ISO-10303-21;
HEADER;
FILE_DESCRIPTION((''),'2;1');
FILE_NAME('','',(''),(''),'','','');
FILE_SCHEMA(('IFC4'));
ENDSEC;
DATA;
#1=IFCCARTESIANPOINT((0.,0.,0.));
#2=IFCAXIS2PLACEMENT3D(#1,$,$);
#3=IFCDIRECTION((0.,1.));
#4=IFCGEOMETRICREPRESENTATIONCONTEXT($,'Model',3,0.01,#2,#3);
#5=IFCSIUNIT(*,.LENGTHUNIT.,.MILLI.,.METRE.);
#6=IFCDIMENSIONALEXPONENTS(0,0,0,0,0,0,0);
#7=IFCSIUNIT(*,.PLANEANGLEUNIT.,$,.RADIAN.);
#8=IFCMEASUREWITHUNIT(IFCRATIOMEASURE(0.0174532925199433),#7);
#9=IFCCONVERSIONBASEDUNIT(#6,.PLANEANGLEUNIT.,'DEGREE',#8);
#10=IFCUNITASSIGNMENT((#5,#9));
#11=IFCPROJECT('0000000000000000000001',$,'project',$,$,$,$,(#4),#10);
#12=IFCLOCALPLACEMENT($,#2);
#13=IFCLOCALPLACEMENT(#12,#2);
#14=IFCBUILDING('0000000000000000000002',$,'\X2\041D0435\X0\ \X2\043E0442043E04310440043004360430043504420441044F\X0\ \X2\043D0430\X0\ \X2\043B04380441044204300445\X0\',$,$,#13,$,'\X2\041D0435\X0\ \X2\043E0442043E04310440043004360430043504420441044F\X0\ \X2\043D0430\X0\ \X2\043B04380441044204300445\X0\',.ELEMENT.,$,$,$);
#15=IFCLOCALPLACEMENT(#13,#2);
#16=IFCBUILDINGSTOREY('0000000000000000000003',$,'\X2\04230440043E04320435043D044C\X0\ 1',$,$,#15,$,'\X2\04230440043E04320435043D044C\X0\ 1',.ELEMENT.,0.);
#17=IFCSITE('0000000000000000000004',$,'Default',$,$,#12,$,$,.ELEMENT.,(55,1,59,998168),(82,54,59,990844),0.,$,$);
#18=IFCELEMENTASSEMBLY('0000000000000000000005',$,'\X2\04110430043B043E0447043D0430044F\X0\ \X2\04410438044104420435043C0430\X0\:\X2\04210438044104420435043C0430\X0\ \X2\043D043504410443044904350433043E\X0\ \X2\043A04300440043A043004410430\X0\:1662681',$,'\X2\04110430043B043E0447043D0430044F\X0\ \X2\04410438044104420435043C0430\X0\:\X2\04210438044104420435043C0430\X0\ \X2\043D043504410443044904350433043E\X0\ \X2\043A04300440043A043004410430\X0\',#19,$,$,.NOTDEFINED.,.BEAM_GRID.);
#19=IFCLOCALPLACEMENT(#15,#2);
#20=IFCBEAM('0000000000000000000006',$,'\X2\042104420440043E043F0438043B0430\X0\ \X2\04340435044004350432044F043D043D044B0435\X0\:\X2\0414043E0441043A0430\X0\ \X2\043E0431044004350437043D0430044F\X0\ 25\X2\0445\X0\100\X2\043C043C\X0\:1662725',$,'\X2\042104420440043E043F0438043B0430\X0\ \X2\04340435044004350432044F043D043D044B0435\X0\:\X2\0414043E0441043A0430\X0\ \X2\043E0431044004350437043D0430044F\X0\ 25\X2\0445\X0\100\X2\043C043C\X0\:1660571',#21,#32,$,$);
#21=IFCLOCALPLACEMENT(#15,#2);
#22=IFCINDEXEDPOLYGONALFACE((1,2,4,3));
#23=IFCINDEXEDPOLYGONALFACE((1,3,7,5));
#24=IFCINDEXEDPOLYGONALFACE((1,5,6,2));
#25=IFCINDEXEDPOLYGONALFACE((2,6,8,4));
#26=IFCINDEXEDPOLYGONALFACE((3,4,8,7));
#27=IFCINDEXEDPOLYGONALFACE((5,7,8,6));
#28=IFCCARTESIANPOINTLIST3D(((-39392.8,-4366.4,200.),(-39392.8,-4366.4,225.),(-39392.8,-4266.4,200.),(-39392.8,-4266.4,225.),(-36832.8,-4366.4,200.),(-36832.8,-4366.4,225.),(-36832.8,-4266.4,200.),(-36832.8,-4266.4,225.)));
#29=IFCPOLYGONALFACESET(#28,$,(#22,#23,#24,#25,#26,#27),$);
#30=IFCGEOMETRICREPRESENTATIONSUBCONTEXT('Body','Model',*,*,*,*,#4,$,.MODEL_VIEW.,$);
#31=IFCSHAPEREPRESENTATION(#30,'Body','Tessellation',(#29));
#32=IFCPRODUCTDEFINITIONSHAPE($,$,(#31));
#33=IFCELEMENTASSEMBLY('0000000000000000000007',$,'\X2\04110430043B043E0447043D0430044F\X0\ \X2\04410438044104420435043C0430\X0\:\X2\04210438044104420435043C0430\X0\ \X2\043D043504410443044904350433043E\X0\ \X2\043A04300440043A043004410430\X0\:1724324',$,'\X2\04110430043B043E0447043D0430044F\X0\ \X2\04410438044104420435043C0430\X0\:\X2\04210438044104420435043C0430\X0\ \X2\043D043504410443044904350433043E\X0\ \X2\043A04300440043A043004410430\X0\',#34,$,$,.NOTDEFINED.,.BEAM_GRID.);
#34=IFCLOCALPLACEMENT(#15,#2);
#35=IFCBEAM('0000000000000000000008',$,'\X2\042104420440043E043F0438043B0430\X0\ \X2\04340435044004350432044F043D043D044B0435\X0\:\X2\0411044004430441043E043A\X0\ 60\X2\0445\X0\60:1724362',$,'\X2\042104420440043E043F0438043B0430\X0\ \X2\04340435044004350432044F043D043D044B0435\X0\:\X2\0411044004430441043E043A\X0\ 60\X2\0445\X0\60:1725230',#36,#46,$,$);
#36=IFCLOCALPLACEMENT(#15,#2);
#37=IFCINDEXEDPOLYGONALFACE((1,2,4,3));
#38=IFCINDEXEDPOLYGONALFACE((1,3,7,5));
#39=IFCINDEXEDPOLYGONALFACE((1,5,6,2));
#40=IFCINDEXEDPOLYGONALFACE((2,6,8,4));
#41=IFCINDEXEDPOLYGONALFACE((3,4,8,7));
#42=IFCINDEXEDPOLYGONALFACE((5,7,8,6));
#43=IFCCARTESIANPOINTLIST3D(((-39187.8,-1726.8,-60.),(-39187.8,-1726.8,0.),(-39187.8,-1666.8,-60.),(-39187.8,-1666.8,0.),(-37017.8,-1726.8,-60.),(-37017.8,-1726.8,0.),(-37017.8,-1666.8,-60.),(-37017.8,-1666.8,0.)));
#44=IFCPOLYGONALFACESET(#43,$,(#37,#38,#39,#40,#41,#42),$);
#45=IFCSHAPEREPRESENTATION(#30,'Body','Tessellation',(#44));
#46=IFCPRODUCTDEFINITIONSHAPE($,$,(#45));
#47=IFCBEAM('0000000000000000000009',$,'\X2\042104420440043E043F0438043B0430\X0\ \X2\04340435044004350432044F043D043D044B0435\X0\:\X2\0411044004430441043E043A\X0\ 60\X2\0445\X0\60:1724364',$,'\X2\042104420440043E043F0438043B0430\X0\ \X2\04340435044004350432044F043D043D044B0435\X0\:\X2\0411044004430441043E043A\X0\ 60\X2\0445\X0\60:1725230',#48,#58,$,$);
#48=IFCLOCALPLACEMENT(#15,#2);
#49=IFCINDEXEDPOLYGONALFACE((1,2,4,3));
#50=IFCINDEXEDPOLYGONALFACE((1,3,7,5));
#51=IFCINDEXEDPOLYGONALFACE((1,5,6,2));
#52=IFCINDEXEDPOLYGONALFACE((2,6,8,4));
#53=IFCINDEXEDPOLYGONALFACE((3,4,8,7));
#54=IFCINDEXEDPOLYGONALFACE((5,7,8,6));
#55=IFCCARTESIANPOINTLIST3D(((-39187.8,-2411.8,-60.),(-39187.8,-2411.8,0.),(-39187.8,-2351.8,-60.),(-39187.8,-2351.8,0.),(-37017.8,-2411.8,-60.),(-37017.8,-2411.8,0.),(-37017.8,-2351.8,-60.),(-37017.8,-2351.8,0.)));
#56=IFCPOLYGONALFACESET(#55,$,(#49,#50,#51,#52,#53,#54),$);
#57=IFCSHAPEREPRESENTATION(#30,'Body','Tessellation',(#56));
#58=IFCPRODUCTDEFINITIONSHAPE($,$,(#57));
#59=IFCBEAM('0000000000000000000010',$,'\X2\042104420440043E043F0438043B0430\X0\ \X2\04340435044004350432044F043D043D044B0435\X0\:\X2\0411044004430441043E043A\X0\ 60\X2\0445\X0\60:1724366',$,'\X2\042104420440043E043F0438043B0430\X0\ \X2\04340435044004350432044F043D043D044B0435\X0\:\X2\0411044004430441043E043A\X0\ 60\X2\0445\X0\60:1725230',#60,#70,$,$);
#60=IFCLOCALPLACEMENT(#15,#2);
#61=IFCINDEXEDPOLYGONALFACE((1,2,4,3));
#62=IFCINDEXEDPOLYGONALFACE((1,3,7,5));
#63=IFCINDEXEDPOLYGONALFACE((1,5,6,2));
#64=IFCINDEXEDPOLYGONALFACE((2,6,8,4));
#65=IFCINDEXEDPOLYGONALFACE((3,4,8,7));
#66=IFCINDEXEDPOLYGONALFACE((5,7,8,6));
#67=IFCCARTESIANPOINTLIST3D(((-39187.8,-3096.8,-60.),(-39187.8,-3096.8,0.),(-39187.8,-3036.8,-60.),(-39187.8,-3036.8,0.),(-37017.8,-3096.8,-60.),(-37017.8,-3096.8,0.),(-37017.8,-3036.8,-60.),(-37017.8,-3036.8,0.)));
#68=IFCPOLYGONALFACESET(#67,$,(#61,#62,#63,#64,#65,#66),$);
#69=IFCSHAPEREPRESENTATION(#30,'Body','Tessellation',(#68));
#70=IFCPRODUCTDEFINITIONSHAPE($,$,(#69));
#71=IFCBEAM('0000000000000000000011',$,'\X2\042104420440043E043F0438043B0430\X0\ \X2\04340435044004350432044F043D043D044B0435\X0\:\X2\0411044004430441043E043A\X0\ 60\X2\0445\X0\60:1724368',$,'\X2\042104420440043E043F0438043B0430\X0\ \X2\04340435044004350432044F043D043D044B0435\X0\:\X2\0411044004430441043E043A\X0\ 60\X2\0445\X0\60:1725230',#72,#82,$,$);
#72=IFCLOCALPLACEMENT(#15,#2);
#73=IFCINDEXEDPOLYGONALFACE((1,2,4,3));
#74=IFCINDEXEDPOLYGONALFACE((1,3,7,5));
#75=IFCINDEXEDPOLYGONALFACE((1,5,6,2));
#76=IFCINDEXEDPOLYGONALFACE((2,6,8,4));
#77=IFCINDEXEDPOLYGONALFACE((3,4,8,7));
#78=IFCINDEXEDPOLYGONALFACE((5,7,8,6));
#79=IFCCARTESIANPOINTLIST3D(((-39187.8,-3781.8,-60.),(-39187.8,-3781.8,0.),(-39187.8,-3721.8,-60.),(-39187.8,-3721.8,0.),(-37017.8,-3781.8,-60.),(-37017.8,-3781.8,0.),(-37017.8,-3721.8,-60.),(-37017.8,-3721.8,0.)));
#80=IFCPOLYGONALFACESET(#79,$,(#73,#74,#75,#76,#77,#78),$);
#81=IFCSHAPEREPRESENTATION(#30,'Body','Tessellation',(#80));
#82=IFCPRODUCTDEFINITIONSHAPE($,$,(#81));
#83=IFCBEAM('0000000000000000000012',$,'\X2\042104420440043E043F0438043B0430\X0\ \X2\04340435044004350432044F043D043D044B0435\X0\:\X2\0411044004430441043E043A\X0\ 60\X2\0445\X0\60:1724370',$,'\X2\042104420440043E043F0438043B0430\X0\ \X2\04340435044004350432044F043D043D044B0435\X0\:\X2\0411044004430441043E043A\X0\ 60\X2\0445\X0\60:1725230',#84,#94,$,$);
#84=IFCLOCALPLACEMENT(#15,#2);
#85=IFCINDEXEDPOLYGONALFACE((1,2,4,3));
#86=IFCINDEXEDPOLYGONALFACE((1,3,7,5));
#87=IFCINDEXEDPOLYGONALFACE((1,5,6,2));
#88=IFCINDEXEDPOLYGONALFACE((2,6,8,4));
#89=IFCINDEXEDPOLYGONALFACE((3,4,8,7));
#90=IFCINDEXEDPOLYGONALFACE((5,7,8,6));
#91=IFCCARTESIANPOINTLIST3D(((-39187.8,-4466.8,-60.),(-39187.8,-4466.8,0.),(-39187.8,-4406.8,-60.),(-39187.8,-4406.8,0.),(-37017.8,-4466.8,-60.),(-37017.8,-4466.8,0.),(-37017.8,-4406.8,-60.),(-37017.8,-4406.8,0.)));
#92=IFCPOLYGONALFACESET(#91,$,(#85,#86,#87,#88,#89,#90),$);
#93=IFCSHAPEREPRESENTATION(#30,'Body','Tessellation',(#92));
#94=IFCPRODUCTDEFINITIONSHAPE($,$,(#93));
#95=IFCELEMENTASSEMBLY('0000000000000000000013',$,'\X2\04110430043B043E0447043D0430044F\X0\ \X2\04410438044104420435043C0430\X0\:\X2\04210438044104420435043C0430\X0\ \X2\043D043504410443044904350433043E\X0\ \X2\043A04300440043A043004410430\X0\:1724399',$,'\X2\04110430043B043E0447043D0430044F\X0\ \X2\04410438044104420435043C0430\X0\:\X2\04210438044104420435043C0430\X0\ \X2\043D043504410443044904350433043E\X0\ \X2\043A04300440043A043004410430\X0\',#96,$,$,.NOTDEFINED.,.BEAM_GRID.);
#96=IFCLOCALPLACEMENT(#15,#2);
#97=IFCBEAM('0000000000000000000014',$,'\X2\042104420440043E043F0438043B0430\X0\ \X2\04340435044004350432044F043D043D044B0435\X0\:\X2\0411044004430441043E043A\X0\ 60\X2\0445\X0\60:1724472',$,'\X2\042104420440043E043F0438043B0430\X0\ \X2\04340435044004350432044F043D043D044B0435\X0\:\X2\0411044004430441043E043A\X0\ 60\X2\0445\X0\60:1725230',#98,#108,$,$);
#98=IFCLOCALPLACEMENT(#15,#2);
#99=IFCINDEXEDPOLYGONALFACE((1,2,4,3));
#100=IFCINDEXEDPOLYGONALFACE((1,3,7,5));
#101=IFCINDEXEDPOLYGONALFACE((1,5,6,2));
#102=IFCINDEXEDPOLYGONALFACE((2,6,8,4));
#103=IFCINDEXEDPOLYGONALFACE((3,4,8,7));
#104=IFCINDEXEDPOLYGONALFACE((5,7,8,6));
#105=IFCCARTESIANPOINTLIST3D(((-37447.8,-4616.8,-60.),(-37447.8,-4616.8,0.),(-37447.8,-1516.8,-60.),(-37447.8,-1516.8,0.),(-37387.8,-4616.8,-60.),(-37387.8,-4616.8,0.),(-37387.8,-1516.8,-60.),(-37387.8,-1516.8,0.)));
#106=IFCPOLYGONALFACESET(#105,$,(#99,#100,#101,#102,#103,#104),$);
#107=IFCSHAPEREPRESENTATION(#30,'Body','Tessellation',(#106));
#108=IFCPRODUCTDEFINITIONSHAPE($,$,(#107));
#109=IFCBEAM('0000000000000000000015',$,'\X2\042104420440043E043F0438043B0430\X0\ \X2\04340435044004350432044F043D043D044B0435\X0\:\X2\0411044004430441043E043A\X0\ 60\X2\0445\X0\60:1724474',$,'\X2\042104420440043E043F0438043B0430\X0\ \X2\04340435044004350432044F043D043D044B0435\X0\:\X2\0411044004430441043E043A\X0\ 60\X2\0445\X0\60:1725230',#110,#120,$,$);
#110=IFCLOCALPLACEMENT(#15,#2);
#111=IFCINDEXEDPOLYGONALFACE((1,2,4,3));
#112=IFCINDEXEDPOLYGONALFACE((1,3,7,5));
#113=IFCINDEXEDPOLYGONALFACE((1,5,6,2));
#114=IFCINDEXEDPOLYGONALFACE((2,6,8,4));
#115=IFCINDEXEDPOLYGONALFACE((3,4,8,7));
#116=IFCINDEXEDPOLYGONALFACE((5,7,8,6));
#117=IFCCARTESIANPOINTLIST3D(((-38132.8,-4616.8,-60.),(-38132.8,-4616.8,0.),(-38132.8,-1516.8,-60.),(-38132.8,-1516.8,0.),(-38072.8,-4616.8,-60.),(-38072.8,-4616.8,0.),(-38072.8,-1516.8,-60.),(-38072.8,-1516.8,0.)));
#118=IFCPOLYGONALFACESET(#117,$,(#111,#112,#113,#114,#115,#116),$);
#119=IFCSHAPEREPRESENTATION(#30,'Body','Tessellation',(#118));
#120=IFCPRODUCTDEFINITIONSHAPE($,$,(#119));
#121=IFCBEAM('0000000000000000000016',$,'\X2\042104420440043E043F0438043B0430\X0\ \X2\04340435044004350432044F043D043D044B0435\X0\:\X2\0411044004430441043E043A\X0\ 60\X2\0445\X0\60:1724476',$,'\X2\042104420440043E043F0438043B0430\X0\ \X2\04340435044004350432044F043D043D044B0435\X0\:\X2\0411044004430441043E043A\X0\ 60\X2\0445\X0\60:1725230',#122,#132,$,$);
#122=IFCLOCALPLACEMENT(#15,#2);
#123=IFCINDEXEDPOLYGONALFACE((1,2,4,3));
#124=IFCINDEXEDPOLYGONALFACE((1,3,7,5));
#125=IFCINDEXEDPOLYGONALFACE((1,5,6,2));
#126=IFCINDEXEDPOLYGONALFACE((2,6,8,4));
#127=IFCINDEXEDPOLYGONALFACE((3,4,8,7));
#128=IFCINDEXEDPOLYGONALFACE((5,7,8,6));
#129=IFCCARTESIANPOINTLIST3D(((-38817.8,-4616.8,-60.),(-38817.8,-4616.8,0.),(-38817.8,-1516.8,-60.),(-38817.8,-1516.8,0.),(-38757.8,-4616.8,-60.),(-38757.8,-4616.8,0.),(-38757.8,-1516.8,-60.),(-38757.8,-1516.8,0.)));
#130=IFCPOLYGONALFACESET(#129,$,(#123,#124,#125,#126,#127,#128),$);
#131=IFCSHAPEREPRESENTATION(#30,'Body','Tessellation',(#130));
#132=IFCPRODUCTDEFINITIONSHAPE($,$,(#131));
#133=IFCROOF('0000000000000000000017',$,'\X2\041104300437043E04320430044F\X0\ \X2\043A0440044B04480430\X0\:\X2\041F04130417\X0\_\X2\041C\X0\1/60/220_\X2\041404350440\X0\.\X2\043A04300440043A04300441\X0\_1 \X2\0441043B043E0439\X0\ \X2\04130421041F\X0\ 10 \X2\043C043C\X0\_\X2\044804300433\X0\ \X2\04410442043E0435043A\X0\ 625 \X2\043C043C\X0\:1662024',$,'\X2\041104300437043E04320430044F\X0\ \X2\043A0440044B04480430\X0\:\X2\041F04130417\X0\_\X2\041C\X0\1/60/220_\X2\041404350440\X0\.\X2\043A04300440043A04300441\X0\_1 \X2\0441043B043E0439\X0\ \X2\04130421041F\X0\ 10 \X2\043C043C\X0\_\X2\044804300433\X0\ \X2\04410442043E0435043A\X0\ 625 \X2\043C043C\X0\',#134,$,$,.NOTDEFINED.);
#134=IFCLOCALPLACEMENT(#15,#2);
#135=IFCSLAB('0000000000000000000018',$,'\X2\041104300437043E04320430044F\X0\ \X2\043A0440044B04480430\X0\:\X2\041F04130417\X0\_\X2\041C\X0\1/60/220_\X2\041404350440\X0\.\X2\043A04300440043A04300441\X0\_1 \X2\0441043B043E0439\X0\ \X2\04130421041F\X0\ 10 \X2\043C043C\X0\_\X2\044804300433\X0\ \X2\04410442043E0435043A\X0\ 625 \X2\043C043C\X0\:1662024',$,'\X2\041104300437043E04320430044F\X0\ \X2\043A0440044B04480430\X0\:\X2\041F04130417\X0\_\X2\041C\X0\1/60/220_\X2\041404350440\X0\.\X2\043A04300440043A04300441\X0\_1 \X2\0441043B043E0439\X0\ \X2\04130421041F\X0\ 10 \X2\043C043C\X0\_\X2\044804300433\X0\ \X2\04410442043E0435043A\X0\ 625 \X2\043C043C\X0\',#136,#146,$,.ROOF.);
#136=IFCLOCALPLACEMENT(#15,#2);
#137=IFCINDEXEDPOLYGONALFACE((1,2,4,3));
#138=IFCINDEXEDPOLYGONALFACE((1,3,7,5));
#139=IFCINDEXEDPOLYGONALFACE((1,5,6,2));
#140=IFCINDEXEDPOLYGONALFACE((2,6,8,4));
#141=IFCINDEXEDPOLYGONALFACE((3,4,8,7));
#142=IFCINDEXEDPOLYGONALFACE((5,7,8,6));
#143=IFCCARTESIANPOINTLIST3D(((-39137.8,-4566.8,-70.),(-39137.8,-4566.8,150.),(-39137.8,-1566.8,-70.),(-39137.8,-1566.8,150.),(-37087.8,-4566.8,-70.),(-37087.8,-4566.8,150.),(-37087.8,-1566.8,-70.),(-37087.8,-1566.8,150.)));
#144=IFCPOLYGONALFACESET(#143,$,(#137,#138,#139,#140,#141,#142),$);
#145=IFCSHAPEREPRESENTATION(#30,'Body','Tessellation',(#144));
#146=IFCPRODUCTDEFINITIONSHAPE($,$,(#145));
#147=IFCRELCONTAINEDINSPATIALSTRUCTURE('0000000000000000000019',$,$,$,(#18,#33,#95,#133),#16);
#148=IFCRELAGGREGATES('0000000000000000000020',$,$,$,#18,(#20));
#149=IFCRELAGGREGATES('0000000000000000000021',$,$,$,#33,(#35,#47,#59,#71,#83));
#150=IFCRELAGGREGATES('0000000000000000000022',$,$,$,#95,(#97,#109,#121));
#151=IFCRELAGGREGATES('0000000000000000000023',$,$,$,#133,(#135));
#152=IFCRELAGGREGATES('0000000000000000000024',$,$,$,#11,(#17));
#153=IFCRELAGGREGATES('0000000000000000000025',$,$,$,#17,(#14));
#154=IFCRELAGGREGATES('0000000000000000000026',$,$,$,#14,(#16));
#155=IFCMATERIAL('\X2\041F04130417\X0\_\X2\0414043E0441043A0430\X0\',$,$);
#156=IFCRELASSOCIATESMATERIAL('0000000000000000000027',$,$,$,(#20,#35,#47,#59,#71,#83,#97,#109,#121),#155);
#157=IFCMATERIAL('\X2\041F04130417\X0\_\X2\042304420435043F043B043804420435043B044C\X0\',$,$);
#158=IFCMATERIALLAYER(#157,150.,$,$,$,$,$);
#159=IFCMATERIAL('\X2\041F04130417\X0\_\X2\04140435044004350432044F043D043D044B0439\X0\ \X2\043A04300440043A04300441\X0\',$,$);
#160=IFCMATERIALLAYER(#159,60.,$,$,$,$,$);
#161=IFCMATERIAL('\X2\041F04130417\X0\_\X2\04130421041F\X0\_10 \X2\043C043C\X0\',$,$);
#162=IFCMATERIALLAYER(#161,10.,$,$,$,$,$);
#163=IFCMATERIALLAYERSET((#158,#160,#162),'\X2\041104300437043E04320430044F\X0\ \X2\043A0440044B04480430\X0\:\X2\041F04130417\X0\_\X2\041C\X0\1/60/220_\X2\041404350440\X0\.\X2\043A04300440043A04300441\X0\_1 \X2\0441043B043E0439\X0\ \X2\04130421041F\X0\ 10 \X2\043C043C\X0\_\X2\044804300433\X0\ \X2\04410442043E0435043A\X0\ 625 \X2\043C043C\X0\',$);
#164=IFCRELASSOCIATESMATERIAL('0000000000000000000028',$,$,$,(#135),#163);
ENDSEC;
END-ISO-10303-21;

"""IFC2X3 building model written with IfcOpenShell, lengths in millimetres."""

from ifc_helpers import new_model, entity, si_unit, converted_unit, direction, frame, frame_2d, origin, origin_2d_with_axis, place, context, subcontext, project, spatial, rectangle, extrude, material, layer, layer_set, element, aggregate, save


model = new_model("IFC2X3")

# Units and contexts
model_context = context("Model", 3, precision=0.01, world=origin(), true_north=direction((0.0, 1.0)))
body_context = subcontext(model_context, "Body", "Model", "MODEL_VIEW")
ifc_project = project(units=[si_unit("LENGTHUNIT", "METRE", prefix="MILLI"), converted_unit("PLANEANGLEUNIT", "DEGREE", entity("IfcRatioMeasure", 0.0174532925199433), si_unit("PLANEANGLEUNIT", "RADIAN"), dimensions=[0, 0, 0, 0, 0, 0, 0])], contexts=[model_context])

# Site, building, storey
site_placement = place(None, origin())
site = spatial("IfcSite", under=ifc_project, at=site_placement, Name="Default", CompositionType="ELEMENT", RefLatitude=(55, 1, 59, 998168), RefLongitude=(82, 54, 59, 990844), RefElevation=0.0)
building_placement = place(site_placement, origin())
building = spatial("IfcBuilding", under=site, at=building_placement, Name="Не отображается на листах", LongName="Не отображается на листах", CompositionType="ELEMENT")
storey_placement = place(building_placement, frame((0.0, 0.0, 0.0)))
storey = spatial("IfcBuildingStorey", under=building, at=storey_placement, Name="Уровень 1", LongName="Уровень 1", CompositionType="ELEMENT", Elevation=0.0)

# Element assemblies, beams
ifc_material_1 = material(Name="ПГЗ_Доска")
assembly_1_placement = place(storey_placement, origin())
assembly_1 = element("IfcElementAssembly", 1, at=assembly_1_placement, inside=storey, Name="Балочная система:Система несущего каркаса:1662681", ObjectType="Балочная система:Система несущего каркаса", AssemblyPlace="NOTDEFINED", PredefinedType="BEAM_GRID")
beam_1_placement = place(assembly_1_placement, frame((-39392.8, -4316.4, 0.0)))
beam_1 = element("IfcBeam", 2, at=beam_1_placement, material=ifc_material_1, Name="Стропила деревянные:Доска обрезная 25х100мм:1662725", ObjectType="Стропила деревянные:Доска обрезная 25х100мм:1660571", context=body_context, shape_type="SweptSolid", body=[
    extrude(rectangle(XDim=25.0, YDim=100.0, at=origin_2d_with_axis()), frame((0.0, 0.0, 212.5), z_axis=(1.0, 0.0, 0.0), x_axis=(0.0, 0.0, -1.0)), (0.0, 0.0, 1.0), 2560.0),
])
aggregate(assembly_1, [beam_1])
assembly_2_placement = place(storey_placement, origin())
assembly_2 = element("IfcElementAssembly", 3, at=assembly_2_placement, inside=storey, Name="Балочная система:Система несущего каркаса:1724324", ObjectType="Балочная система:Система несущего каркаса", AssemblyPlace="NOTDEFINED", PredefinedType="BEAM_GRID")
beam_2_placement = place(assembly_2_placement, frame((-39187.8, -1696.8, 0.0)))
beam_2 = element("IfcBeam", 4, at=beam_2_placement, material=ifc_material_1, Name="Стропила деревянные:Брусок 60х60:1724362", ObjectType="Стропила деревянные:Брусок 60х60:1725230", context=body_context, shape_type="SweptSolid", body=[
    extrude(rectangle(XDim=60.0, YDim=60.0, at=frame_2d((0.0, 0.0), x_axis=(1.0, 0.0))), frame((0.0, 0.0, -30.0), z_axis=(1.0, 0.0, 0.0), x_axis=(0.0, 0.0, -1.0)), (0.0, 0.0, 1.0), 2170.0),
])
beam_3_placement = place(assembly_2_placement, frame((-39187.8, -2381.8, 0.0)))
beam_3 = element("IfcBeam", 5, at=beam_3_placement, material=ifc_material_1, Name="Стропила деревянные:Брусок 60х60:1724364", ObjectType="Стропила деревянные:Брусок 60х60:1725230", context=body_context, shape_type="SweptSolid", body=[
    extrude(rectangle(XDim=60.0, YDim=60.0, at=frame_2d((0.0, 0.0), x_axis=(1.0, 0.0))), frame((0.0, 0.0, -30.0), z_axis=(1.0, 0.0, 0.0), x_axis=(0.0, 0.0, -1.0)), (0.0, 0.0, 1.0), 2170.0),
])
beam_4_placement = place(assembly_2_placement, frame((-39187.8, -3066.8, 0.0)))
beam_4 = element("IfcBeam", 6, at=beam_4_placement, material=ifc_material_1, Name="Стропила деревянные:Брусок 60х60:1724366", ObjectType="Стропила деревянные:Брусок 60х60:1725230", context=body_context, shape_type="SweptSolid", body=[
    extrude(rectangle(XDim=60.0, YDim=60.0, at=frame_2d((0.0, 0.0), x_axis=(1.0, 0.0))), frame((0.0, 0.0, -30.0), z_axis=(1.0, 0.0, 0.0), x_axis=(0.0, 0.0, -1.0)), (0.0, 0.0, 1.0), 2170.0),
])
beam_5_placement = place(assembly_2_placement, frame((-39187.8, -3751.8, 0.0)))
beam_5 = element("IfcBeam", 7, at=beam_5_placement, material=ifc_material_1, Name="Стропила деревянные:Брусок 60х60:1724368", ObjectType="Стропила деревянные:Брусок 60х60:1725230", context=body_context, shape_type="SweptSolid", body=[
    extrude(rectangle(XDim=60.0, YDim=60.0, at=frame_2d((0.0, 0.0), x_axis=(1.0, 0.0))), frame((0.0, 0.0, -30.0), z_axis=(1.0, 0.0, 0.0), x_axis=(0.0, 0.0, -1.0)), (0.0, 0.0, 1.0), 2170.0),
])
beam_6_placement = place(assembly_2_placement, frame((-39187.8, -4436.8, 0.0)))
beam_6 = element("IfcBeam", 8, at=beam_6_placement, material=ifc_material_1, Name="Стропила деревянные:Брусок 60х60:1724370", ObjectType="Стропила деревянные:Брусок 60х60:1725230", context=body_context, shape_type="SweptSolid", body=[
    extrude(rectangle(XDim=60.0, YDim=60.0, at=frame_2d((0.0, 0.0), x_axis=(1.0, 0.0))), frame((0.0, 0.0, -30.0), z_axis=(1.0, 0.0, 0.0), x_axis=(0.0, 0.0, -1.0)), (0.0, 0.0, 1.0), 2170.0),
])
aggregate(assembly_2, [beam_2, beam_3, beam_4, beam_5, beam_6])
assembly_3_placement = place(storey_placement, origin())
assembly_3 = element("IfcElementAssembly", 9, at=assembly_3_placement, inside=storey, Name="Балочная система:Система несущего каркаса:1724399", ObjectType="Балочная система:Система несущего каркаса", AssemblyPlace="NOTDEFINED", PredefinedType="BEAM_GRID")
beam_7_placement = place(assembly_3_placement, frame((-37417.8, -1516.8, 0.0), z_axis=(0.0, 0.0, 1.0), x_axis=(0.0, -1.0, 0.0)))
beam_7 = element("IfcBeam", 10, at=beam_7_placement, material=ifc_material_1, Name="Стропила деревянные:Брусок 60х60:1724472", ObjectType="Стропила деревянные:Брусок 60х60:1725230", context=body_context, shape_type="SweptSolid", body=[
    extrude(rectangle(XDim=60.0, YDim=60.0, at=frame_2d((0.0, 0.0), x_axis=(1.0, 0.0))), frame((0.0, 0.0, -30.0), z_axis=(1.0, 0.0, 0.0), x_axis=(0.0, 0.0, -1.0)), (0.0, 0.0, 1.0), 3100.0),
])
beam_8_placement = place(assembly_3_placement, frame((-38102.8, -1516.8, 0.0), z_axis=(0.0, 0.0, 1.0), x_axis=(0.0, -1.0, 0.0)))
beam_8 = element("IfcBeam", 11, at=beam_8_placement, material=ifc_material_1, Name="Стропила деревянные:Брусок 60х60:1724474", ObjectType="Стропила деревянные:Брусок 60х60:1725230", context=body_context, shape_type="SweptSolid", body=[
    extrude(rectangle(XDim=60.0, YDim=60.0, at=frame_2d((0.0, 0.0), x_axis=(1.0, 0.0))), frame((0.0, 0.0, -30.0), z_axis=(1.0, 0.0, 0.0), x_axis=(0.0, 0.0, -1.0)), (0.0, 0.0, 1.0), 3100.0),
])
beam_9_placement = place(assembly_3_placement, frame((-38787.8, -1516.8, 0.0), z_axis=(0.0, 0.0, 1.0), x_axis=(0.0, -1.0, 0.0)))
beam_9 = element("IfcBeam", 12, at=beam_9_placement, material=ifc_material_1, Name="Стропила деревянные:Брусок 60х60:1724476", ObjectType="Стропила деревянные:Брусок 60х60:1725230", context=body_context, shape_type="SweptSolid", body=[
    extrude(rectangle(XDim=60.0, YDim=60.0, at=frame_2d((0.0, 0.0), x_axis=(1.0, 0.0))), frame((0.0, 0.0, -30.0), z_axis=(1.0, 0.0, 0.0), x_axis=(0.0, 0.0, -1.0)), (0.0, 0.0, 1.0), 3100.0),
])
aggregate(assembly_3, [beam_7, beam_8, beam_9])

# Roof, slab
roof_placement = place(storey_placement, frame((-39137.8, -4566.8, -70.0)))
roof = element("IfcRoof", 13, at=roof_placement, inside=storey, Name="Базовая крыша:ПГЗ_М1/60/220_Дер.каркас_1 слой ГСП 10 мм_шаг стоек 625 мм:1662024", ObjectType="Базовая крыша:ПГЗ_М1/60/220_Дер.каркас_1 слой ГСП 10 мм_шаг стоек 625 мм", ShapeType="NOTDEFINED")
ifc_material_2 = material(Name="ПГЗ_Утеплитель")
ifc_layer_1 = layer(ifc_material_2, 150.0)
ifc_material_3 = material(Name="ПГЗ_Деревянный каркас")
ifc_layer_2 = layer(ifc_material_3, 60.0)
ifc_material_4 = material(Name="ПГЗ_ГСП_10 мм")
ifc_layer_3 = layer(ifc_material_4, 10.0)
ifc_layer_set = layer_set([ifc_layer_1, ifc_layer_2, ifc_layer_3], Name="Базовая крыша:ПГЗ_М1/60/220_Дер.каркас_1 слой ГСП 10 мм_шаг стоек 625 мм")
slab_placement = place(roof_placement, origin())
slab = element("IfcSlab", 14, at=slab_placement, material=ifc_layer_set, Name="Базовая крыша:ПГЗ_М1/60/220_Дер.каркас_1 слой ГСП 10 мм_шаг стоек 625 мм:1662024", ObjectType="Базовая крыша:ПГЗ_М1/60/220_Дер.каркас_1 слой ГСП 10 мм_шаг стоек 625 мм", PredefinedType="ROOF", context=body_context, shape_type="SweptSolid", body=[
    extrude(rectangle(XDim=2050.0, YDim=3000.0, at=origin_2d_with_axis()), frame((1025.0, 1500.0, 0.0)), (0.0, 0.0, 1.0), 220.0),
])
aggregate(roof, [slab])

save(model, "model.ifc")
